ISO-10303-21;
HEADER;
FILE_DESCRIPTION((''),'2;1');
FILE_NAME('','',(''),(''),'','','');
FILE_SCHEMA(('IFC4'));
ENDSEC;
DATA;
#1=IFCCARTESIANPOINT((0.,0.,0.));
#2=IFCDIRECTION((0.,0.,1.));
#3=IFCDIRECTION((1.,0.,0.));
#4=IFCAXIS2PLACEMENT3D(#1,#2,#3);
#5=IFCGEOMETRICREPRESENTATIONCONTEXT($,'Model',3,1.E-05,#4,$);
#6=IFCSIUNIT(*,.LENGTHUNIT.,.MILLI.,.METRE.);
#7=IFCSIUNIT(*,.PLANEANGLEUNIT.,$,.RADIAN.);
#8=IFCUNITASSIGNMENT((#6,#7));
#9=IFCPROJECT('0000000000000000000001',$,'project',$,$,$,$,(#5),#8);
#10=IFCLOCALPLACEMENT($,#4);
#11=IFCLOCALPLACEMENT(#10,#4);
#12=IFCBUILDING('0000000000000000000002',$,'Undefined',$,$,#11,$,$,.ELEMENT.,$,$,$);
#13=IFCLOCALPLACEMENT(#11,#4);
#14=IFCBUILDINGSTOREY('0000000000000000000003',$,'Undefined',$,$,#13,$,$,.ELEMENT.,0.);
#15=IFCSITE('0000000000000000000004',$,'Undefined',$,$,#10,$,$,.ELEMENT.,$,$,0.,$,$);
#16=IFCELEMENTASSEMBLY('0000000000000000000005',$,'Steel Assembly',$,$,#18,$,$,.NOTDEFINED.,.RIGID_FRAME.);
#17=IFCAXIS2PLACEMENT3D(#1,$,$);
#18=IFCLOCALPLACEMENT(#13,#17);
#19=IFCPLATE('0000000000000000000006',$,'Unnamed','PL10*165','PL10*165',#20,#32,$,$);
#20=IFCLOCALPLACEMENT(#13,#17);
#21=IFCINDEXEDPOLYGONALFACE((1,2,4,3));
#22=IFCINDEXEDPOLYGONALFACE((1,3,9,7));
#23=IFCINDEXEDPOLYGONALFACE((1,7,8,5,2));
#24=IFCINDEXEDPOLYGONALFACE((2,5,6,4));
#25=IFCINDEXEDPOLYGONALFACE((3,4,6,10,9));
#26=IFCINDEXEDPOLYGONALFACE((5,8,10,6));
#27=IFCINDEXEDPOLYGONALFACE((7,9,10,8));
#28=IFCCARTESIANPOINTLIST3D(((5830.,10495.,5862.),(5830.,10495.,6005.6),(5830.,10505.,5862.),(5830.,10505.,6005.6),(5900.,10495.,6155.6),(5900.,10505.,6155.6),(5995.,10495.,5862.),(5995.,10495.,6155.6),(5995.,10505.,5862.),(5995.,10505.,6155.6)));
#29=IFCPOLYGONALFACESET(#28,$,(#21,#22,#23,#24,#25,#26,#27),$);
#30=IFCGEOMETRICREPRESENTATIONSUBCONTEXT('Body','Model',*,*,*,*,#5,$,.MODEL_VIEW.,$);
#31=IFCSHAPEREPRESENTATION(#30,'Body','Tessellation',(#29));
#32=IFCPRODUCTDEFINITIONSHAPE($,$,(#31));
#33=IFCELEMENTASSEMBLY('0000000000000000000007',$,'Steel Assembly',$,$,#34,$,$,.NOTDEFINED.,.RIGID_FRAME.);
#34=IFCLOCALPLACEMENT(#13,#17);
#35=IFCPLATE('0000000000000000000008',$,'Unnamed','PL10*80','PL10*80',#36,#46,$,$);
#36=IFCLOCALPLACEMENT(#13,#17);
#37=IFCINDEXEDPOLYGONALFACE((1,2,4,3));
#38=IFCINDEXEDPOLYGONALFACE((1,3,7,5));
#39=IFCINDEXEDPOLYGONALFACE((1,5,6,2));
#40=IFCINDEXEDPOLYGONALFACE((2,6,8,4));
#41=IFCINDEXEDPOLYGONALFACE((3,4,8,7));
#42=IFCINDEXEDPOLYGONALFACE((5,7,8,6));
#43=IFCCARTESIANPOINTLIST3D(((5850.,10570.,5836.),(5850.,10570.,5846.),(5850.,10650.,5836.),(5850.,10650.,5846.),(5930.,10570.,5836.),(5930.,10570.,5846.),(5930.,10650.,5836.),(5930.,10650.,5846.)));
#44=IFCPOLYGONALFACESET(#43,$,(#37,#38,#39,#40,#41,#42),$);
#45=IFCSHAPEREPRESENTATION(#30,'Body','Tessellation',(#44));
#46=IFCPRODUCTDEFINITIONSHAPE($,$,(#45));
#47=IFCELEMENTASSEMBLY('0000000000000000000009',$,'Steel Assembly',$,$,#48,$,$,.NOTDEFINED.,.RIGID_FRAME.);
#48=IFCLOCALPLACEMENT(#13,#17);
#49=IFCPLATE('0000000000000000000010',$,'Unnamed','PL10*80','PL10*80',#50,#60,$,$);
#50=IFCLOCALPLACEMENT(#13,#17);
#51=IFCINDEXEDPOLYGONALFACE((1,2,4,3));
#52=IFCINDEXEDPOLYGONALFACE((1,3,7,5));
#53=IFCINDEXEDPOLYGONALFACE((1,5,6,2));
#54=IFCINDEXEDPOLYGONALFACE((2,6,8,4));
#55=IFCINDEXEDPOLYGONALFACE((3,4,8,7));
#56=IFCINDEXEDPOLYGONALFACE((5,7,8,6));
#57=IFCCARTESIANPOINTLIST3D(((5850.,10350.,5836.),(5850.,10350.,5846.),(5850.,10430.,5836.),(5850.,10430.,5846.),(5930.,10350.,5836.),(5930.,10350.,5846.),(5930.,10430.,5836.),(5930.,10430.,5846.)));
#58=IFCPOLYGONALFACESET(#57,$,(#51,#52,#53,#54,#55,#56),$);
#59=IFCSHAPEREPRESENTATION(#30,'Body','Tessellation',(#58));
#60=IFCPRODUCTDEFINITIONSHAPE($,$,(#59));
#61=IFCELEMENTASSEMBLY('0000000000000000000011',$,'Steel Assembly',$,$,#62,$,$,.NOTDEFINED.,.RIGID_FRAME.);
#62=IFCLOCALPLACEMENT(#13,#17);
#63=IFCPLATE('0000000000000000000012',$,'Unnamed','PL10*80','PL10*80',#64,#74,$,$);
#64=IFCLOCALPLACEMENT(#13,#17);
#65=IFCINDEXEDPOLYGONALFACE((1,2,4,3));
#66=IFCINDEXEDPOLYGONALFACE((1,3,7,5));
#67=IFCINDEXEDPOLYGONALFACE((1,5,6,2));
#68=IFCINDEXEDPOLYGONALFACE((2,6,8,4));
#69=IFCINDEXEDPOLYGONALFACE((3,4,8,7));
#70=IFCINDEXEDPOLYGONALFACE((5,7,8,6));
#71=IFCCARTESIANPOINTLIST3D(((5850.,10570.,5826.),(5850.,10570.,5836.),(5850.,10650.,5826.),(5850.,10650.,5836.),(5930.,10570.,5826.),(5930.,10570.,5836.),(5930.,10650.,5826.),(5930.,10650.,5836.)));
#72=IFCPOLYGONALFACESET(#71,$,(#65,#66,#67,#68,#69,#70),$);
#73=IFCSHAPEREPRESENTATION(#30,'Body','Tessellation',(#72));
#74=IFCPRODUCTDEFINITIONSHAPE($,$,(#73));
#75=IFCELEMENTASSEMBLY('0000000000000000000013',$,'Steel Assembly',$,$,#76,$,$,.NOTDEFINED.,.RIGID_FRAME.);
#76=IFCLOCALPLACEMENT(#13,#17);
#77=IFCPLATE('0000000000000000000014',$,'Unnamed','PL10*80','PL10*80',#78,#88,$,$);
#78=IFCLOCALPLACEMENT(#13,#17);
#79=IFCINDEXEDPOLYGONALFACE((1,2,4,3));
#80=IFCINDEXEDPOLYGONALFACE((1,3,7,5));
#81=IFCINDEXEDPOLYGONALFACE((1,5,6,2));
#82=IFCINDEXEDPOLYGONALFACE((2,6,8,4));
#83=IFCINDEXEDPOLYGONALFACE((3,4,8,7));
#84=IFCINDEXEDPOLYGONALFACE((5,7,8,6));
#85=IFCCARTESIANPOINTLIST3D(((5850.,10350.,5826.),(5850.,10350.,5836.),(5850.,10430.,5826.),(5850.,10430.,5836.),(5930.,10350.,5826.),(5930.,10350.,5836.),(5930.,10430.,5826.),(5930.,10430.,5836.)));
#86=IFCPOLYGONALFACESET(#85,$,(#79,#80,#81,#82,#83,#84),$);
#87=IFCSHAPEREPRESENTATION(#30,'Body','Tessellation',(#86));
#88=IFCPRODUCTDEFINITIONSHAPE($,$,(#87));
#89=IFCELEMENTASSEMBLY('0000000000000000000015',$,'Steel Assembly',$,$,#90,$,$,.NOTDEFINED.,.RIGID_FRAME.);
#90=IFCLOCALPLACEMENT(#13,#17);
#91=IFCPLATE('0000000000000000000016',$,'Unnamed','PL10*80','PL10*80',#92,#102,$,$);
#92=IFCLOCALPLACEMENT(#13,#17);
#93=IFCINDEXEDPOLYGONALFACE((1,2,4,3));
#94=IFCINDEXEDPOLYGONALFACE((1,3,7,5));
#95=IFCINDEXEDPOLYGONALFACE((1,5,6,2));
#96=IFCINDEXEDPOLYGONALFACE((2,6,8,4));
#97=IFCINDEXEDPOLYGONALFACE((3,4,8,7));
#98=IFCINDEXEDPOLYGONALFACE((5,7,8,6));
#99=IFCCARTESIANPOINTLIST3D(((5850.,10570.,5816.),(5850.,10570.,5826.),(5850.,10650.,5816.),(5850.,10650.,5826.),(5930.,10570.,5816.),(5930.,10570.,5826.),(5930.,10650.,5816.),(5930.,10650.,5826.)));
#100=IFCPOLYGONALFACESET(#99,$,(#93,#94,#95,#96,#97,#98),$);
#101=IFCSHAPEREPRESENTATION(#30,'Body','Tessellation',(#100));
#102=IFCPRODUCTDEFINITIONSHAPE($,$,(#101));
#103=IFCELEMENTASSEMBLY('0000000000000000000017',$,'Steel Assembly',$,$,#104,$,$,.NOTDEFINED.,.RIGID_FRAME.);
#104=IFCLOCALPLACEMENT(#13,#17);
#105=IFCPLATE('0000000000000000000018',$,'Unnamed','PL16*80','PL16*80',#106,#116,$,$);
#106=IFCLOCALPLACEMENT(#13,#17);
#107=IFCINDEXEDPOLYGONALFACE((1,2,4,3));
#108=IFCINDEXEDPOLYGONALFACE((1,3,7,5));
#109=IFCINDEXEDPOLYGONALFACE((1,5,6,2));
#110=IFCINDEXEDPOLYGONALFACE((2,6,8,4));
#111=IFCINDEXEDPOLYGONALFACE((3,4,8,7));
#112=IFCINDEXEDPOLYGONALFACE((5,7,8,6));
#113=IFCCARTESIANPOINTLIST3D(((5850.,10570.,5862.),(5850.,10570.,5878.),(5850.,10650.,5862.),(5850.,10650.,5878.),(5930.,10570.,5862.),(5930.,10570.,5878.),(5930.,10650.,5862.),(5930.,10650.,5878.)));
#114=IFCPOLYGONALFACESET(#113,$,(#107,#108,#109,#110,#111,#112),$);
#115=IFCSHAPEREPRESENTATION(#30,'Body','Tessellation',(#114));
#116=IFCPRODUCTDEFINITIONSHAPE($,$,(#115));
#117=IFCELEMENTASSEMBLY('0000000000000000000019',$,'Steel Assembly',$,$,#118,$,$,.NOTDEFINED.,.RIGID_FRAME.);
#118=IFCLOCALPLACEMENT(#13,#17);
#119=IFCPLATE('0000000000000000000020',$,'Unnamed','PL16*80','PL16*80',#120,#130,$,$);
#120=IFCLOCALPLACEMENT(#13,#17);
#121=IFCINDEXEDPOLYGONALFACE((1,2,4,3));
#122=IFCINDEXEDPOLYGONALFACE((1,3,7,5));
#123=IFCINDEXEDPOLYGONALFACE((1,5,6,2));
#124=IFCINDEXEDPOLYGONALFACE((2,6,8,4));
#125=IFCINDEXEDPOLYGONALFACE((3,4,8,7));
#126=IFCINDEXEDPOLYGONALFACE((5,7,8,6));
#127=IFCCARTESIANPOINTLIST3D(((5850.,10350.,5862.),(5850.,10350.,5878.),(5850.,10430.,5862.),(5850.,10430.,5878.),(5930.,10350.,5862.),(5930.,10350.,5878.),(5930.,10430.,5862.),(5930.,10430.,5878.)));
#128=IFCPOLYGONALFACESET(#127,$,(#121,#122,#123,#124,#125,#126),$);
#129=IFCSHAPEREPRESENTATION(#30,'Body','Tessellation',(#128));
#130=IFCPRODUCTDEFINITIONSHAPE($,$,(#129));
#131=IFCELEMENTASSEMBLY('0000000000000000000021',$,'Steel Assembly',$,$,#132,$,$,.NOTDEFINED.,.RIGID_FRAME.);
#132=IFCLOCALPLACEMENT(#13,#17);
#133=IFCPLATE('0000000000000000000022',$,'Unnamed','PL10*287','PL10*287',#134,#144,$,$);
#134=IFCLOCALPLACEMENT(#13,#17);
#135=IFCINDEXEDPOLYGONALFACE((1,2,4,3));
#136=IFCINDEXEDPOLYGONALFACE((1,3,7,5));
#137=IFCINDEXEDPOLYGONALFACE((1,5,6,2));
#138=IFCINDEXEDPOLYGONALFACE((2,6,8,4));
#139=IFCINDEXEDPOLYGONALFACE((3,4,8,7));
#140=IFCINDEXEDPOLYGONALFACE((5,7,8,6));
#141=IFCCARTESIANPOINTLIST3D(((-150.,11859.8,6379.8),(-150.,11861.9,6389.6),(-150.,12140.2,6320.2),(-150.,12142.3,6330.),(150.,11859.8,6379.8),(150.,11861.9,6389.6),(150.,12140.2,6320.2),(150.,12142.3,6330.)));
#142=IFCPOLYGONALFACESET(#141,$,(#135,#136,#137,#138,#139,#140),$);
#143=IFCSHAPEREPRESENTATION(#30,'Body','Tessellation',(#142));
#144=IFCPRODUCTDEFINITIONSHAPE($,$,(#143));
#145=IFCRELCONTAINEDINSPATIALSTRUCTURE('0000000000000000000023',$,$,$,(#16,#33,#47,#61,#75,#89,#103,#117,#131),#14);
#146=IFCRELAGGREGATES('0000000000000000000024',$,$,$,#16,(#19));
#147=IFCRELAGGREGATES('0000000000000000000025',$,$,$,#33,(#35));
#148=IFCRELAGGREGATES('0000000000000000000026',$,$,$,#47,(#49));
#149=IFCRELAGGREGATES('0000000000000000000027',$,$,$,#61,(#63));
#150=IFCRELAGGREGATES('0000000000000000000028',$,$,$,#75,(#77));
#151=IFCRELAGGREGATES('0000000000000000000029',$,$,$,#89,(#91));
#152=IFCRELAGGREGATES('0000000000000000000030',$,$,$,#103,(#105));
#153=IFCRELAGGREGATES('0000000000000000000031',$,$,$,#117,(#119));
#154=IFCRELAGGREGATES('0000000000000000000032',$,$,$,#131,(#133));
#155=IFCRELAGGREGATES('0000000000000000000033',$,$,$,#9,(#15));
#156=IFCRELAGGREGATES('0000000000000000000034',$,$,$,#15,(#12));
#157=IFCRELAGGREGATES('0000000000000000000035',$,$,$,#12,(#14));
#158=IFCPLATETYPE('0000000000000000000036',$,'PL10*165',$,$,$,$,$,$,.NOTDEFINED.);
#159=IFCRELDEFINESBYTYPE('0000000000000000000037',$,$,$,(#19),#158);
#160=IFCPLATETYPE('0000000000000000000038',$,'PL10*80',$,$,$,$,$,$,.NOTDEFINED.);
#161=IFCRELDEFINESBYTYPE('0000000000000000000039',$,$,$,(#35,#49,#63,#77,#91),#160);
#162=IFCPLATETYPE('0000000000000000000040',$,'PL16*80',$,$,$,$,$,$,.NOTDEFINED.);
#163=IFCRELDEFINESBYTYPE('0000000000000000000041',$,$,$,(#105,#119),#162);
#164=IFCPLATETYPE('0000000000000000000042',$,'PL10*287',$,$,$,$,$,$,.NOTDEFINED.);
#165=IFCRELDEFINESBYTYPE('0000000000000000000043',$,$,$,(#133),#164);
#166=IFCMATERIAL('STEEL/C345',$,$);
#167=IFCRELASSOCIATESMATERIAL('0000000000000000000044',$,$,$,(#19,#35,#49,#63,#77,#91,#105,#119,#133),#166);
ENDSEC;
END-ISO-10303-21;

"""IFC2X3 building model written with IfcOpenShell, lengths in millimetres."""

from ifc_helpers import new_model, si_unit, frame, origin_with_axes, place, context, subcontext, project, spatial, polyline, outline, extrude, material, type_object, element, aggregate, save


model = new_model("IFC2X3")

# Units and contexts
model_context = context("Model", 3, precision=1e-05, world=origin_with_axes())
body_context = subcontext(model_context, "Body", "Model", "MODEL_VIEW")
ifc_project = project(units=[si_unit("LENGTHUNIT", "METRE", prefix="MILLI"), si_unit("PLANEANGLEUNIT", "RADIAN")], contexts=[model_context])

# Site, building, storey
site_placement = place(None, origin_with_axes())
site = spatial("IfcSite", under=ifc_project, at=site_placement, Name="Undefined", CompositionType="ELEMENT", RefElevation=0.0)
building_placement = place(site_placement, origin_with_axes())
building = spatial("IfcBuilding", under=site, at=building_placement, Name="Undefined", CompositionType="ELEMENT")
storey_placement = place(building_placement, origin_with_axes())
storey = spatial("IfcBuildingStorey", under=building, at=storey_placement, Name="Undefined", CompositionType="ELEMENT", Elevation=0.0)

# Shared definitions
ifc_material_1 = material(Name="STEEL/C345")

# Element assemblies, plates
assembly_1_placement = place(storey_placement, origin_with_axes())
assembly_1 = element("IfcElementAssembly", 1, at=assembly_1_placement, inside=storey, Name="Steel Assembly", AssemblyPlace="NOTDEFINED", PredefinedType="RIGID_FRAME")
plate_type_1 = type_object("IfcPlateType", Name="PL10*165", PredefinedType="NOTDEFINED")
plate_1_placement = place(assembly_1_placement, frame((5995.0, 10500.0, 5862.0), z_axis=(0.0, 1.0, 0.0), x_axis=(-1.0, 0.0, 0.0)))
plate_1 = element("IfcPlate", 2, at=plate_1_placement, type_object=plate_type_1, material=ifc_material_1, Name="Unnamed", Description="PL10*165", ObjectType="PL10*165", context=body_context, shape_type="SweptSolid", body=[
    extrude(outline(polyline([(0.0, 0.0), (165.0, 0.0), (165.0, 143.6), (95.0, 293.6), (0.0, 293.6), (0.0, 0.0)])), frame((0.0, 0.0, -5.0), z_axis=(0.0, 0.0, 1.0), x_axis=(1.0, 0.0, 0.0)), (0.0, 0.0, 1.0), 10.0),
])
aggregate(assembly_1, [plate_1])
assembly_2_placement = place(storey_placement, origin_with_axes())
assembly_2 = element("IfcElementAssembly", 3, at=assembly_2_placement, inside=storey, Name="Steel Assembly", AssemblyPlace="NOTDEFINED", PredefinedType="RIGID_FRAME")
plate_type_2 = type_object("IfcPlateType", Name="PL10*80", PredefinedType="NOTDEFINED")
plate_2_placement = place(assembly_2_placement, frame((5850.0, 10650.0, 5841.0), z_axis=(0.0, 0.0, 1.0), x_axis=(0.0, -1.0, 0.0)))
plate_2 = element("IfcPlate", 4, at=plate_2_placement, type_object=plate_type_2, material=ifc_material_1, Name="Unnamed", Description="PL10*80", ObjectType="PL10*80", context=body_context, shape_type="SweptSolid", body=[
    extrude(outline(polyline([(0.0, 0.0), (80.0, 0.0), (80.0, 80.0), (0.0, 80.0), (0.0, 0.0)])), frame((0.0, 0.0, -5.0), z_axis=(0.0, 0.0, 1.0), x_axis=(1.0, 0.0, 0.0)), (0.0, 0.0, 1.0), 10.0),
])
aggregate(assembly_2, [plate_2])
assembly_3_placement = place(storey_placement, origin_with_axes())
assembly_3 = element("IfcElementAssembly", 5, at=assembly_3_placement, inside=storey, Name="Steel Assembly", AssemblyPlace="NOTDEFINED", PredefinedType="RIGID_FRAME")
plate_3_placement = place(assembly_3_placement, frame((5850.0, 10350.0, 5841.0), z_axis=(0.0, 0.0, -1.0), x_axis=(0.0, 1.0, 0.0)))
plate_3 = element("IfcPlate", 6, at=plate_3_placement, type_object=plate_type_2, material=ifc_material_1, Name="Unnamed", Description="PL10*80", ObjectType="PL10*80", context=body_context, shape_type="SweptSolid", body=[
    extrude(outline(polyline([(0.0, 0.0), (80.0, 0.0), (80.0, 80.0), (0.0, 80.0), (0.0, 0.0)])), frame((0.0, 0.0, -5.0), z_axis=(0.0, 0.0, 1.0), x_axis=(1.0, 0.0, 0.0)), (0.0, 0.0, 1.0), 10.0),
])
aggregate(assembly_3, [plate_3])
assembly_4_placement = place(storey_placement, origin_with_axes())
assembly_4 = element("IfcElementAssembly", 7, at=assembly_4_placement, inside=storey, Name="Steel Assembly", AssemblyPlace="NOTDEFINED", PredefinedType="RIGID_FRAME")
plate_4_placement = place(assembly_4_placement, frame((5850.0, 10650.0, 5831.0), z_axis=(0.0, 0.0, 1.0), x_axis=(0.0, -1.0, 0.0)))
plate_4 = element("IfcPlate", 8, at=plate_4_placement, type_object=plate_type_2, material=ifc_material_1, Name="Unnamed", Description="PL10*80", ObjectType="PL10*80", context=body_context, shape_type="SweptSolid", body=[
    extrude(outline(polyline([(0.0, 0.0), (80.0, 0.0), (80.0, 80.0), (0.0, 80.0), (0.0, 0.0)])), frame((0.0, 0.0, -5.0), z_axis=(0.0, 0.0, 1.0), x_axis=(1.0, 0.0, 0.0)), (0.0, 0.0, 1.0), 10.0),
])
aggregate(assembly_4, [plate_4])
assembly_5_placement = place(storey_placement, origin_with_axes())
assembly_5 = element("IfcElementAssembly", 9, at=assembly_5_placement, inside=storey, Name="Steel Assembly", AssemblyPlace="NOTDEFINED", PredefinedType="RIGID_FRAME")
plate_5_placement = place(assembly_5_placement, frame((5850.0, 10350.0, 5831.0), z_axis=(0.0, 0.0, -1.0), x_axis=(0.0, 1.0, 0.0)))
plate_5 = element("IfcPlate", 10, at=plate_5_placement, type_object=plate_type_2, material=ifc_material_1, Name="Unnamed", Description="PL10*80", ObjectType="PL10*80", context=body_context, shape_type="SweptSolid", body=[
    extrude(outline(polyline([(0.0, 0.0), (80.0, 0.0), (80.0, 80.0), (0.0, 80.0), (0.0, 0.0)])), frame((0.0, 0.0, -5.0), z_axis=(0.0, 0.0, 1.0), x_axis=(1.0, 0.0, 0.0)), (0.0, 0.0, 1.0), 10.0),
])
aggregate(assembly_5, [plate_5])
assembly_6_placement = place(storey_placement, origin_with_axes())
assembly_6 = element("IfcElementAssembly", 11, at=assembly_6_placement, inside=storey, Name="Steel Assembly", AssemblyPlace="NOTDEFINED", PredefinedType="RIGID_FRAME")
plate_6_placement = place(assembly_6_placement, frame((5850.0, 10650.0, 5821.0), z_axis=(0.0, 0.0, 1.0), x_axis=(0.0, -1.0, 0.0)))
plate_6 = element("IfcPlate", 12, at=plate_6_placement, type_object=plate_type_2, material=ifc_material_1, Name="Unnamed", Description="PL10*80", ObjectType="PL10*80", context=body_context, shape_type="SweptSolid", body=[
    extrude(outline(polyline([(0.0, 0.0), (80.0, 0.0), (80.0, 80.0), (0.0, 80.0), (0.0, 0.0)])), frame((0.0, 0.0, -5.0), z_axis=(0.0, 0.0, 1.0), x_axis=(1.0, 0.0, 0.0)), (0.0, 0.0, 1.0), 10.0),
])
aggregate(assembly_6, [plate_6])
assembly_7_placement = place(storey_placement, origin_with_axes())
assembly_7 = element("IfcElementAssembly", 13, at=assembly_7_placement, inside=storey, Name="Steel Assembly", AssemblyPlace="NOTDEFINED", PredefinedType="RIGID_FRAME")
plate_type_3 = type_object("IfcPlateType", Name="PL16*80", PredefinedType="NOTDEFINED")
plate_7_placement = place(assembly_7_placement, frame((5850.0, 10650.0, 5870.0), z_axis=(0.0, 0.0, 1.0), x_axis=(0.0, -1.0, 0.0)))
plate_7 = element("IfcPlate", 14, at=plate_7_placement, type_object=plate_type_3, material=ifc_material_1, Name="Unnamed", Description="PL16*80", ObjectType="PL16*80", context=body_context, shape_type="SweptSolid", body=[
    extrude(outline(polyline([(0.0, 0.0), (80.0, 0.0), (80.0, 80.0), (0.0, 80.0), (0.0, 0.0)])), frame((0.0, 0.0, -8.0), z_axis=(0.0, 0.0, 1.0), x_axis=(1.0, 0.0, 0.0)), (0.0, 0.0, 1.0), 16.0),
])
aggregate(assembly_7, [plate_7])
assembly_8_placement = place(storey_placement, origin_with_axes())
assembly_8 = element("IfcElementAssembly", 15, at=assembly_8_placement, inside=storey, Name="Steel Assembly", AssemblyPlace="NOTDEFINED", PredefinedType="RIGID_FRAME")
plate_8_placement = place(assembly_8_placement, frame((5850.0, 10350.0, 5870.0), z_axis=(0.0, 0.0, -1.0), x_axis=(0.0, 1.0, 0.0)))
plate_8 = element("IfcPlate", 16, at=plate_8_placement, type_object=plate_type_3, material=ifc_material_1, Name="Unnamed", Description="PL16*80", ObjectType="PL16*80", context=body_context, shape_type="SweptSolid", body=[
    extrude(outline(polyline([(0.0, 0.0), (80.0, 0.0), (80.0, 80.0), (0.0, 80.0), (0.0, 0.0)])), frame((0.0, 0.0, -8.0), z_axis=(0.0, 0.0, 1.0), x_axis=(1.0, 0.0, 0.0)), (0.0, 0.0, 1.0), 16.0),
])
aggregate(assembly_8, [plate_8])
assembly_9_placement = place(storey_placement, origin_with_axes())
assembly_9 = element("IfcElementAssembly", 17, at=assembly_9_placement, inside=storey, Name="Steel Assembly", AssemblyPlace="NOTDEFINED", PredefinedType="RIGID_FRAME")
plate_type_4 = type_object("IfcPlateType", Name="PL10*287", PredefinedType="NOTDEFINED")
plate_9_placement = place(assembly_9_placement, frame((150.0, 12141.3, 6325.1), z_axis=(0.0, 0.207859, 0.978159), x_axis=(-1.0, 0.0, 0.0)))
plate_9 = element("IfcPlate", 18, at=plate_9_placement, type_object=plate_type_4, material=ifc_material_1, Name="Unnamed", Description="PL10*287", ObjectType="PL10*287", context=body_context, shape_type="SweptSolid", body=[
    extrude(outline(polyline([(0.0, 0.0), (300.0, 0.0), (300.0, 286.7), (0.0, 286.7), (0.0, 0.0)])), frame((0.0, 0.0, -5.0), z_axis=(0.0, 0.0, 1.0), x_axis=(1.0, 0.0, 0.0)), (0.0, 0.0, 1.0), 10.0),
])
aggregate(assembly_9, [plate_9])

save(model, "model.ifc")
